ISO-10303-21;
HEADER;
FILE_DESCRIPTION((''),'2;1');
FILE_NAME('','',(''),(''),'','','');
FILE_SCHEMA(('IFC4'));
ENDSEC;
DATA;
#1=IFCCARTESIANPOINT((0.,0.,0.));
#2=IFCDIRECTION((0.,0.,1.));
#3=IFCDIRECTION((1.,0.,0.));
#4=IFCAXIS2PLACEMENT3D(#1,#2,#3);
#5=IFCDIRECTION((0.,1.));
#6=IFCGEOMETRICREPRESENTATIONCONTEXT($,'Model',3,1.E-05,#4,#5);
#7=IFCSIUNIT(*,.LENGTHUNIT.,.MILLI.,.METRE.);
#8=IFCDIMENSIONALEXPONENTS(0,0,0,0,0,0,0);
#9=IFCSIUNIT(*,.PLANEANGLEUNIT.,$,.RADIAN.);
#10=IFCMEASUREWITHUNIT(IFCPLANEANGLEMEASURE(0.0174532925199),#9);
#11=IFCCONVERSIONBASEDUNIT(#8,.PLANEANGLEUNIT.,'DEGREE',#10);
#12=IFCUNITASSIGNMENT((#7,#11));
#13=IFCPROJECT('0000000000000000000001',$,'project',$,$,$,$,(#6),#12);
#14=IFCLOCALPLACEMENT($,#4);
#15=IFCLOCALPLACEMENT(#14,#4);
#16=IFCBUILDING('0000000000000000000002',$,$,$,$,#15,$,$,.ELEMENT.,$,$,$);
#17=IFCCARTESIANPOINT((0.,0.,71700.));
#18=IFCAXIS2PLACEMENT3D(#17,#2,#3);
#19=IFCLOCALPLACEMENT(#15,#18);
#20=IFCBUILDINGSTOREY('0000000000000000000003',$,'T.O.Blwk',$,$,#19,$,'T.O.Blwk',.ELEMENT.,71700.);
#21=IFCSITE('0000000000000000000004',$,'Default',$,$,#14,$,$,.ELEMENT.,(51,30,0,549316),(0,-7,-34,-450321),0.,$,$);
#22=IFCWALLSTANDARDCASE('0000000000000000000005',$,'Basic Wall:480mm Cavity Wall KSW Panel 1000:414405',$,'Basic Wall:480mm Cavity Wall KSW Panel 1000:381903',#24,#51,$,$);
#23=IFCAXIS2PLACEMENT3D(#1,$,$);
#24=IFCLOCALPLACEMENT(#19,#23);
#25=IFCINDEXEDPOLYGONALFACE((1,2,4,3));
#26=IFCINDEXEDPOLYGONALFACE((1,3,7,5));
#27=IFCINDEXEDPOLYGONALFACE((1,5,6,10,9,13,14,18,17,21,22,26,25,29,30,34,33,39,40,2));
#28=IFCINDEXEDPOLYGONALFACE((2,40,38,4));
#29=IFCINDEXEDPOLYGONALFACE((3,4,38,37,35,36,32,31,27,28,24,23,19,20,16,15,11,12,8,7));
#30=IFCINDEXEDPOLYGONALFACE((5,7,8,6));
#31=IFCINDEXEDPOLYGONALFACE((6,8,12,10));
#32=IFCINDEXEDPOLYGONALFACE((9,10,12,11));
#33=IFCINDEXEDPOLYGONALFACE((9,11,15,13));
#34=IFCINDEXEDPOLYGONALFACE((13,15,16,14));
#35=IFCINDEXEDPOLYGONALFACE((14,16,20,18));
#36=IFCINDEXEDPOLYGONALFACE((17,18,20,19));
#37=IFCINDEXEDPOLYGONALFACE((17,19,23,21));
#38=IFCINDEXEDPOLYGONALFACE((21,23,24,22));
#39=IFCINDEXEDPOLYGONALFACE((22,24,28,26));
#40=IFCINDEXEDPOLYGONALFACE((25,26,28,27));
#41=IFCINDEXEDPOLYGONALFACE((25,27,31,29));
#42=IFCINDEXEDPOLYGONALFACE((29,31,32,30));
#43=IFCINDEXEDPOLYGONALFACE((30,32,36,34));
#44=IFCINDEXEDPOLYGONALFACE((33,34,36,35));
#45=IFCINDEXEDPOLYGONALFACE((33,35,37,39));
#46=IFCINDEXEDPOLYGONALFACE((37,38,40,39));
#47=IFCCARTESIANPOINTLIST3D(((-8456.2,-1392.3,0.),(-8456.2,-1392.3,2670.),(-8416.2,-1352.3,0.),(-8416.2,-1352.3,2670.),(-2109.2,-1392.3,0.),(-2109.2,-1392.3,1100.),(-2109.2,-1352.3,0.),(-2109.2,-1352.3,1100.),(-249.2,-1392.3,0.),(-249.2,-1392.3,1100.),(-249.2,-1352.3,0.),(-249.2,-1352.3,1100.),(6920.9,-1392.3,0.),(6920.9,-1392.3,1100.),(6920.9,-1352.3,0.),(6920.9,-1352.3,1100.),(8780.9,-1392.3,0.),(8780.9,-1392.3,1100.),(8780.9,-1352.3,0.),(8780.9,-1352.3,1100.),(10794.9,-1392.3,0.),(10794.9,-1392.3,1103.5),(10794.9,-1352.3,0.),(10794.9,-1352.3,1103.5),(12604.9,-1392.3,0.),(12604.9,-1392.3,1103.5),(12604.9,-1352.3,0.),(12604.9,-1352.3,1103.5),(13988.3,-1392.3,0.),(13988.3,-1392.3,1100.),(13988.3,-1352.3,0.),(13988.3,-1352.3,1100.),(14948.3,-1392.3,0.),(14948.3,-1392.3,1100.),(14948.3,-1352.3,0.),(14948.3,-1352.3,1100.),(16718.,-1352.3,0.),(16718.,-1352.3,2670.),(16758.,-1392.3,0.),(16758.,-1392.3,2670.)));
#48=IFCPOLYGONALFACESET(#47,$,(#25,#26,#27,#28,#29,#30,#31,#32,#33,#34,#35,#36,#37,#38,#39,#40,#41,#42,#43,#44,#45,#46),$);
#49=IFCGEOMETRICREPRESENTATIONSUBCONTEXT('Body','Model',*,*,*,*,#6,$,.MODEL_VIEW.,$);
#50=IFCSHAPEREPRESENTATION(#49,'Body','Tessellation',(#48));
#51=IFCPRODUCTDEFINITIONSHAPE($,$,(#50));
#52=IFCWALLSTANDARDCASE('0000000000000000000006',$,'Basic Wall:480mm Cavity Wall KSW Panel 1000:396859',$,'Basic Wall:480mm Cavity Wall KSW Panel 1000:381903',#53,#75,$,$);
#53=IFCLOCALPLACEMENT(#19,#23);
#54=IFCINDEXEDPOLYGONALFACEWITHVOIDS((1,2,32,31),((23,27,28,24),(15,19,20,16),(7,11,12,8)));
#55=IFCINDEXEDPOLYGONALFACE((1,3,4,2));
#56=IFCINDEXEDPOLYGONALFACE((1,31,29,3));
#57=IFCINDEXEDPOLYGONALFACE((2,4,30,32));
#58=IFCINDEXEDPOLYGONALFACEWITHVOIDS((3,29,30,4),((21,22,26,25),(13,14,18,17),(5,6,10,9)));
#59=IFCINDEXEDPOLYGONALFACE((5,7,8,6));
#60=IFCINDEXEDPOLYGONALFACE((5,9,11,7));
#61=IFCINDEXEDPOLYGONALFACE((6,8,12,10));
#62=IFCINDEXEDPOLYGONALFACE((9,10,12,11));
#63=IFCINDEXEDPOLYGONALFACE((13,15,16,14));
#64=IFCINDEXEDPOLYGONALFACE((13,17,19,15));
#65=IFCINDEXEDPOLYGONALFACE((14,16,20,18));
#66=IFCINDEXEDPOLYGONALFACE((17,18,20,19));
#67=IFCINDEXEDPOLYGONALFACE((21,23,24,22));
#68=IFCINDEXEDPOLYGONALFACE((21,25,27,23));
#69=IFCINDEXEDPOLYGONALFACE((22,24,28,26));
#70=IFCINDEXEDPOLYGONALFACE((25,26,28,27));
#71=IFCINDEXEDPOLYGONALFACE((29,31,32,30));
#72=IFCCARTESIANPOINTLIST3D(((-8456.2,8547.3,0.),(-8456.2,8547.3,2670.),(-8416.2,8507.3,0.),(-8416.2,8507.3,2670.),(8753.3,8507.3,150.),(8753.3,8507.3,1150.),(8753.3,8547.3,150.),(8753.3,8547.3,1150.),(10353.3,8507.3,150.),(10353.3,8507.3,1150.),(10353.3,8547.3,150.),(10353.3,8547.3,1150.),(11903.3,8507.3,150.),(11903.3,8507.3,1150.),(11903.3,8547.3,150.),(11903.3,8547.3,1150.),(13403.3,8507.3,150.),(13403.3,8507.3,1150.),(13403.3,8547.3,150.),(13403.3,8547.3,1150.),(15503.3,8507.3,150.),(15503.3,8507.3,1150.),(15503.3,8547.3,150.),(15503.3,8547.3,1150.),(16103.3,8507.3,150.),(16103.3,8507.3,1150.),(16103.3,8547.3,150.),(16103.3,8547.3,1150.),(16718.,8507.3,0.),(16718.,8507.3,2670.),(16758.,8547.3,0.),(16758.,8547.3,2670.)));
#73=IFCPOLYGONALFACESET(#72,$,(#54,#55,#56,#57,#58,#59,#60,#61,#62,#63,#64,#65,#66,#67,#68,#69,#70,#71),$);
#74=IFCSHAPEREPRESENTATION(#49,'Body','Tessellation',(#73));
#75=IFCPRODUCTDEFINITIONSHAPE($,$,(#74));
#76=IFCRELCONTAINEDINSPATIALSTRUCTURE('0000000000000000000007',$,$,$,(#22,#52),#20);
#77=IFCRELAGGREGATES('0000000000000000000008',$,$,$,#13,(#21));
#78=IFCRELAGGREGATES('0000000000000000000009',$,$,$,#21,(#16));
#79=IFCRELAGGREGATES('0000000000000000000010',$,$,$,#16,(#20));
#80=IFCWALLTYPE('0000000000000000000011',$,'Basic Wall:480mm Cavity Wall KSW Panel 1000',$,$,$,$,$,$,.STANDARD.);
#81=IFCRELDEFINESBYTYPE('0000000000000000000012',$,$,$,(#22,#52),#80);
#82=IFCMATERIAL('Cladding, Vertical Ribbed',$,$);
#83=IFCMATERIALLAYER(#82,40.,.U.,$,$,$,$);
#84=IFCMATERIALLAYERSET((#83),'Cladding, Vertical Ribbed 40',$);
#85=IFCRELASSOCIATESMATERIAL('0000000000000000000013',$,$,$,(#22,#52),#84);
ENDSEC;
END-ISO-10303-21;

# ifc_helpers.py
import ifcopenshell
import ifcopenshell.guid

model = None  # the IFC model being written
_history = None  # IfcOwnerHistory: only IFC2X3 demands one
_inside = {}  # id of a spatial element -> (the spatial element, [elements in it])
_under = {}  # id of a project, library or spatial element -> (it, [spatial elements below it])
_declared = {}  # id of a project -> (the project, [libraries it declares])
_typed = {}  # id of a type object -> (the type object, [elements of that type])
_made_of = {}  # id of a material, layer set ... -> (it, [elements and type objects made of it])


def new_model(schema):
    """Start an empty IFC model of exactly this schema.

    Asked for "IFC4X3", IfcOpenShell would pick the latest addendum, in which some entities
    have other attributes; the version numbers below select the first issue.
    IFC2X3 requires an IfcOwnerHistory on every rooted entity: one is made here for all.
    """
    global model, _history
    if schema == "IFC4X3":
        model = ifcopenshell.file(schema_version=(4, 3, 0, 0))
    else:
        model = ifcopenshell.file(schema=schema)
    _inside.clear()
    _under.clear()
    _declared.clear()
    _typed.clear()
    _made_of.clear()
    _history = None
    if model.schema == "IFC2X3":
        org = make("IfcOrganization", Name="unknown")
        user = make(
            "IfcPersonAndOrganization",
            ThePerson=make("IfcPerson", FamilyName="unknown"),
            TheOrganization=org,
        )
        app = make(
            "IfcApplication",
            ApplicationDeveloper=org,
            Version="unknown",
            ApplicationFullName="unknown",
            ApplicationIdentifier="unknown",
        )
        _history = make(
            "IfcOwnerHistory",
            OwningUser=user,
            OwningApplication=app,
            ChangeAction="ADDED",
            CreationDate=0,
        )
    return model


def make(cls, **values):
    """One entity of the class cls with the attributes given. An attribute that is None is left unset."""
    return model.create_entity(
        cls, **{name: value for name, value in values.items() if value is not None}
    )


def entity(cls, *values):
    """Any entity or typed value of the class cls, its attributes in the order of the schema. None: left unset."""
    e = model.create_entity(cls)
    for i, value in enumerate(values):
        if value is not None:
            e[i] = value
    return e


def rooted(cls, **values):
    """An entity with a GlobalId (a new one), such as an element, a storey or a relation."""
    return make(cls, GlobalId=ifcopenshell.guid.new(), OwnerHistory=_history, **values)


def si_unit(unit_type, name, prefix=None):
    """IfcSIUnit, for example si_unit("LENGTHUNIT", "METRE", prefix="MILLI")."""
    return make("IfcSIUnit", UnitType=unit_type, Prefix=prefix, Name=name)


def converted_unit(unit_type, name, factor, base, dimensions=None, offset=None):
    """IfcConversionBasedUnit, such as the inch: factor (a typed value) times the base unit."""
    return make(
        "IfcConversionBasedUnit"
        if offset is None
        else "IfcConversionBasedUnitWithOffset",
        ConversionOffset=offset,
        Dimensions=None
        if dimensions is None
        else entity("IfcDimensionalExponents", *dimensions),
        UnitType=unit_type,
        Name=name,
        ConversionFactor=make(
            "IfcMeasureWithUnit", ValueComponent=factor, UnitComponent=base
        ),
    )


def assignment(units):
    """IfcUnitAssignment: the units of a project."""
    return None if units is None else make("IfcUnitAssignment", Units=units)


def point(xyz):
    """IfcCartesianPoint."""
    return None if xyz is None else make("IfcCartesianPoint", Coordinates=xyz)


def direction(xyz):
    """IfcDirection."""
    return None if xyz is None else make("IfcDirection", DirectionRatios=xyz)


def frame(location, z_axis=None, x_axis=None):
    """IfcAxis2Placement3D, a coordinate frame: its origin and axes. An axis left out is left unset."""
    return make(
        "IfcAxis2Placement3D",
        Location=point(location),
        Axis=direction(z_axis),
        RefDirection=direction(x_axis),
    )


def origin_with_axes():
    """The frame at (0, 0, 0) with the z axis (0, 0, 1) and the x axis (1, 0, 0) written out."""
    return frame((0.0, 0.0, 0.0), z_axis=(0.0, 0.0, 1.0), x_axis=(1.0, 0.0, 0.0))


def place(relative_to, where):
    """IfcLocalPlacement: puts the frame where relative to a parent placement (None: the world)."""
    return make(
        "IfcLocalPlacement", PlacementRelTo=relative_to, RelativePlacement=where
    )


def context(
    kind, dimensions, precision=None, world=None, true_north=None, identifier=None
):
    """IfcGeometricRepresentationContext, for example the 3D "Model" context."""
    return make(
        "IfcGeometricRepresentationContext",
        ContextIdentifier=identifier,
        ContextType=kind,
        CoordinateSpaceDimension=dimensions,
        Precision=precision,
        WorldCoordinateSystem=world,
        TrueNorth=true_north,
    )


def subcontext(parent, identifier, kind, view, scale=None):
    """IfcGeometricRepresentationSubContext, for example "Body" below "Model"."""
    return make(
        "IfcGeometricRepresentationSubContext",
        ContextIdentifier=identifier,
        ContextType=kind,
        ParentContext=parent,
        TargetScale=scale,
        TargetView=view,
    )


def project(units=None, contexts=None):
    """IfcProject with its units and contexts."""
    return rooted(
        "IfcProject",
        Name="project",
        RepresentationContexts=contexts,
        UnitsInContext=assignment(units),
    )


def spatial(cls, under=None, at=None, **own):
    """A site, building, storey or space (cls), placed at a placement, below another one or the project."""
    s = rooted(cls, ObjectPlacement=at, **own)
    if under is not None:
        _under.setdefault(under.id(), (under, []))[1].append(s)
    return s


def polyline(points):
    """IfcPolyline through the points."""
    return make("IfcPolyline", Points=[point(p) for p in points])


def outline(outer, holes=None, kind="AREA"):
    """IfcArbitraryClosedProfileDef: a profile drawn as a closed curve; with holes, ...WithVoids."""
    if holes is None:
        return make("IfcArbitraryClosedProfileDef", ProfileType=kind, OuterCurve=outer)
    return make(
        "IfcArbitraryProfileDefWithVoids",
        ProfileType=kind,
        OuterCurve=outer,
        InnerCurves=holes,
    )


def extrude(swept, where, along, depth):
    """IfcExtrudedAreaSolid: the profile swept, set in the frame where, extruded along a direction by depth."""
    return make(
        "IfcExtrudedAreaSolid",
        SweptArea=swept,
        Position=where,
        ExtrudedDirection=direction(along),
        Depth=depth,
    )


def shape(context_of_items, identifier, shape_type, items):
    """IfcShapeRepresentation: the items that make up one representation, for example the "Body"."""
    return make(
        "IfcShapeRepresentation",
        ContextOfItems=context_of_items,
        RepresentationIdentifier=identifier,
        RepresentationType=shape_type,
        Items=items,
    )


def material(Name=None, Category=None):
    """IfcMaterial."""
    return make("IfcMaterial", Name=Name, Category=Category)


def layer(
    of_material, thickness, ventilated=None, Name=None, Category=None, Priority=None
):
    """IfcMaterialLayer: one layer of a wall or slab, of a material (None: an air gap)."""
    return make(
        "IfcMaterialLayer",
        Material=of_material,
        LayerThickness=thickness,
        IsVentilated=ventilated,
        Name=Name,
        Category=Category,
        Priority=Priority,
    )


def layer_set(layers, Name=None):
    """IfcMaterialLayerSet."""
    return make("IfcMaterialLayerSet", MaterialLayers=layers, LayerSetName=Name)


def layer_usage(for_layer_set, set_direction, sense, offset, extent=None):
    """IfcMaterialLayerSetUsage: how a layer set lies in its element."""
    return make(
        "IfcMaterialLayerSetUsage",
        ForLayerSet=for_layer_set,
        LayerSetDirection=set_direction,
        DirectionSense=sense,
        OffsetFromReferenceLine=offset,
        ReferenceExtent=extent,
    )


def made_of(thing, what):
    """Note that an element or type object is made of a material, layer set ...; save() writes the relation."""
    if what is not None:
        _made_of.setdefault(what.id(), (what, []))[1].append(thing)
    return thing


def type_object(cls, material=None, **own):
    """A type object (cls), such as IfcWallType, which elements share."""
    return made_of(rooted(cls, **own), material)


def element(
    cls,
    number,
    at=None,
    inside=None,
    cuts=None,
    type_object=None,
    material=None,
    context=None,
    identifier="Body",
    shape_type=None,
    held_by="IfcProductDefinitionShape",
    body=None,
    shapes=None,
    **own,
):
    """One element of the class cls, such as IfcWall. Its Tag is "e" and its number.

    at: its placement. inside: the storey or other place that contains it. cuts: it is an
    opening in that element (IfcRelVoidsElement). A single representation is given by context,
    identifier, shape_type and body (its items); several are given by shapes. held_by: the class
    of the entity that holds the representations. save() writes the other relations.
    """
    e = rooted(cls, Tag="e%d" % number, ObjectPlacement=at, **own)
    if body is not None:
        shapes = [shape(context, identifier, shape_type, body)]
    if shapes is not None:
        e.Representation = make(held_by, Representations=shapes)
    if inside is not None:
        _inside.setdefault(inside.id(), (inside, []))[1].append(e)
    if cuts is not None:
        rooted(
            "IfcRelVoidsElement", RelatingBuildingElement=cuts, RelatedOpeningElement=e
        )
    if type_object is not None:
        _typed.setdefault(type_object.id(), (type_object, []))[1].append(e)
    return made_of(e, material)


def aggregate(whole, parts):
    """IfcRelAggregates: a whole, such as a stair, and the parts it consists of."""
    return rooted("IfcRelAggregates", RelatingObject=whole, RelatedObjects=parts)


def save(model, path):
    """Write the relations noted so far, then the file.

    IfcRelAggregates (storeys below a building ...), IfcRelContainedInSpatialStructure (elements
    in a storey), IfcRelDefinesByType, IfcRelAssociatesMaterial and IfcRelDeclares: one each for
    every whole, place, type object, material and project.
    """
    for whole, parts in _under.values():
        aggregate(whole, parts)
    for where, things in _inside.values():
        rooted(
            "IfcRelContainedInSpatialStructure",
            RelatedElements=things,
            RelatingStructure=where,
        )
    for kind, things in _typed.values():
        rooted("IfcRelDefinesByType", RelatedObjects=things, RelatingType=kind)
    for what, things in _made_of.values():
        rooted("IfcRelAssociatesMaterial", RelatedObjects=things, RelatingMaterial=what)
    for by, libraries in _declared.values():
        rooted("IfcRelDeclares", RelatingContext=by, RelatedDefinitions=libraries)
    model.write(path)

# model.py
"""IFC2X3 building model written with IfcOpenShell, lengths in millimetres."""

from ifc_helpers import new_model, entity, si_unit, converted_unit, direction, frame, origin_with_axes, place, context, subcontext, project, spatial, polyline, outline, extrude, material, layer, layer_set, layer_usage, type_object, element, save


model = new_model("IFC2X3")

# Units and contexts
model_context = context("Model", 3, precision=1e-05, world=origin_with_axes(), true_north=direction((0.0, 1.0)))
body_context = subcontext(model_context, "Body", "Model", "MODEL_VIEW")
ifc_project = project(units=[si_unit("LENGTHUNIT", "METRE", prefix="MILLI"), converted_unit("PLANEANGLEUNIT", "DEGREE", entity("IfcPlaneAngleMeasure", 0.0174532925199), si_unit("PLANEANGLEUNIT", "RADIAN"), dimensions=[0, 0, 0, 0, 0, 0, 0])], contexts=[model_context])

# Site, building, storey
site_placement = place(None, origin_with_axes())
site = spatial("IfcSite", under=ifc_project, at=site_placement, Name="Default", CompositionType="ELEMENT", RefLatitude=(51, 30, 0, 549316), RefLongitude=(0, -7, -34, -450321), RefElevation=0.0)
building_placement = place(site_placement, origin_with_axes())
building = spatial("IfcBuilding", under=site, at=building_placement, CompositionType="ELEMENT")
storey_placement = place(building_placement, frame((0.0, 0.0, 71700.0), z_axis=(0.0, 0.0, 1.0), x_axis=(1.0, 0.0, 0.0)))
storey = spatial("IfcBuildingStorey", under=building, at=storey_placement, Name="T.O.Blwk", LongName="T.O.Blwk", CompositionType="ELEMENT", Elevation=71700.0)

# Shared definitions
ifc_material_1 = material(Name="Cladding, Vertical Ribbed")
ifc_layer_1 = layer(ifc_material_1, 40.0, ventilated="UNKNOWN")
ifc_layer_set_1 = layer_set([ifc_layer_1], Name="Cladding, Vertical Ribbed 40")
wall_type_1 = type_object("IfcWallType", Name="Basic Wall:480mm Cavity Wall KSW Panel 1000", PredefinedType="STANDARD")

# Wall, openings
ifc_layer_usage_1 = layer_usage(ifc_layer_set_1, "AXIS2", "POSITIVE", -20.0)
wall_1_placement = place(storey_placement, frame((16738.0, -1372.3, 0.0), z_axis=(0.0, 0.0, 1.0), x_axis=(-1.0, 0.0, 0.0)))
wall_1 = element("IfcWallStandardCase", 1, at=wall_1_placement, inside=storey, type_object=wall_type_1, material=ifc_layer_usage_1, Name="Basic Wall:480mm Cavity Wall KSW Panel 1000:414405", ObjectType="Basic Wall:480mm Cavity Wall KSW Panel 1000:381903", context=body_context, shape_type="SweptSolid", body=[
    extrude(outline(polyline([(20.0, -20.0), (25154.3, -20.0), (25194.3, 20.0), (-20.0, 20.0), (20.0, -20.0)])), origin_with_axes(), (0.0, 0.0, 1.0), 2670.0),
])
opening_1_placement = place(wall_1_placement, frame((5038.2, 0.0, 0.0), z_axis=(0.0, 0.0, 1.0), x_axis=(1.0, 0.0, 0.0)))
element("IfcOpeningElement", 2, at=opening_1_placement, cuts=wall_1, context=body_context, shape_type="SweptSolid", body=[
    extrude(outline(polyline([(905.0, 1103.5), (-905.0, 1103.5), (-905.0, 0.0), (905.0, 0.0), (905.0, 1103.5)])), frame((0.0, 20.0, 0.0), z_axis=(0.0, -1.0, 0.0), x_axis=(1.0, 0.0, 0.0)), (0.0, 0.0, 1.0), 40.0),
])
opening_2_placement = place(wall_1_placement, frame((8887.1, 0.0, 0.0), z_axis=(0.0, 0.0, 1.0), x_axis=(1.0, 0.0, 0.0)))
element("IfcOpeningElement", 3, at=opening_2_placement, cuts=wall_1, context=body_context, shape_type="SweptSolid", body=[
    extrude(outline(polyline([(930.0, 1100.0), (-930.0, 1100.0), (-930.0, 0.0), (930.0, 0.0), (930.0, 1100.0)])), frame((0.0, 20.0, 0.0), z_axis=(0.0, -1.0, 0.0), x_axis=(1.0, 0.0, 0.0)), (0.0, 0.0, 1.0), 40.0),
])
opening_3_placement = place(wall_1_placement, frame((17917.3, 0.0, 0.0), z_axis=(0.0, 0.0, 1.0), x_axis=(1.0, 0.0, 0.0)))
element("IfcOpeningElement", 4, at=opening_3_placement, cuts=wall_1, context=body_context, shape_type="SweptSolid", body=[
    extrude(outline(polyline([(-930.0, 0.0), (930.0, 0.0), (930.0, 1100.0), (-930.0, 1100.0), (-930.0, 0.0)])), frame((0.0, 20.0, 0.0), z_axis=(0.0, -1.0, 0.0), x_axis=(1.0, 0.0, 0.0)), (0.0, 0.0, 1.0), 40.0),
])
opening_4_placement = place(wall_1_placement, frame((2269.8, 0.0, 0.0), z_axis=(0.0, 0.0, 1.0), x_axis=(1.0, 0.0, 0.0)))
element("IfcOpeningElement", 5, at=opening_4_placement, cuts=wall_1, context=body_context, shape_type="SweptSolid", body=[
    extrude(outline(polyline([(480.0, 1100.0), (-480.0, 1100.0), (-480.0, 0.0), (480.0, 0.0), (480.0, 1100.0)])), frame((0.0, 20.0, 0.0), z_axis=(0.0, -1.0, 0.0), x_axis=(1.0, 0.0, 0.0)), (0.0, 0.0, 1.0), 40.0),
])

# Wall, openings
ifc_layer_usage_2 = layer_usage(ifc_layer_set_1, "AXIS2", "POSITIVE", -20.0)
wall_2_placement = place(storey_placement, frame((16738.0, 8527.3, 0.0), z_axis=(0.0, 0.0, 1.0), x_axis=(-1.0, 0.0, 0.0)))
wall_2 = element("IfcWallStandardCase", 6, at=wall_2_placement, inside=storey, type_object=wall_type_1, material=ifc_layer_usage_2, Name="Basic Wall:480mm Cavity Wall KSW Panel 1000:396859", ObjectType="Basic Wall:480mm Cavity Wall KSW Panel 1000:381903", context=body_context, shape_type="SweptSolid", body=[
    extrude(outline(polyline([(-20.0, -20.0), (25194.3, -20.0), (25154.3, 20.0), (20.0, 20.0), (-20.0, -20.0)])), origin_with_axes(), (0.0, 0.0, 1.0), 2670.0),
])
opening_5_placement = place(wall_2_placement, frame((4084.8, 0.0, 150.0), z_axis=(0.0, 0.0, 1.0), x_axis=(1.0, 0.0, 0.0)))
element("IfcOpeningElement", 7, at=opening_5_placement, cuts=wall_2, context=body_context, shape_type="SweptSolid", body=[
    extrude(outline(polyline([(-750.0, 1000.0), (-750.0, 0.0), (750.0, 0.0), (750.0, 1000.0), (-750.0, 1000.0)])), frame((0.0, 20.0, 0.0), z_axis=(0.0, -1.0, 0.0), x_axis=(1.0, 0.0, 0.0)), (0.0, 0.0, 1.0), 40.0),
])
opening_6_placement = place(wall_2_placement, frame((934.8, 0.0, 150.0), z_axis=(0.0, 0.0, 1.0), x_axis=(1.0, 0.0, 0.0)))
element("IfcOpeningElement", 8, at=opening_6_placement, cuts=wall_2, context=body_context, shape_type="SweptSolid", body=[
    extrude(outline(polyline([(-300.0, 1000.0), (-300.0, 0.0), (300.0, 0.0), (300.0, 1000.0), (-300.0, 1000.0)])), frame((0.0, 20.0, 0.0), z_axis=(0.0, -1.0, 0.0), x_axis=(1.0, 0.0, 0.0)), (0.0, 0.0, 1.0), 40.0),
])
opening_7_placement = place(wall_2_placement, frame((7184.8, 0.0, 150.0), z_axis=(0.0, 0.0, 1.0), x_axis=(1.0, 0.0, 0.0)))
element("IfcOpeningElement", 9, at=opening_7_placement, cuts=wall_2, context=body_context, shape_type="SweptSolid", body=[
    extrude(outline(polyline([(-800.0, 1000.0), (-800.0, 0.0), (800.0, 0.0), (800.0, 1000.0), (-800.0, 1000.0)])), frame((0.0, 20.0, 0.0), z_axis=(0.0, -1.0, 0.0), x_axis=(1.0, 0.0, 0.0)), (0.0, 0.0, 1.0), 40.0),
])

save(model, "model.ifc")
